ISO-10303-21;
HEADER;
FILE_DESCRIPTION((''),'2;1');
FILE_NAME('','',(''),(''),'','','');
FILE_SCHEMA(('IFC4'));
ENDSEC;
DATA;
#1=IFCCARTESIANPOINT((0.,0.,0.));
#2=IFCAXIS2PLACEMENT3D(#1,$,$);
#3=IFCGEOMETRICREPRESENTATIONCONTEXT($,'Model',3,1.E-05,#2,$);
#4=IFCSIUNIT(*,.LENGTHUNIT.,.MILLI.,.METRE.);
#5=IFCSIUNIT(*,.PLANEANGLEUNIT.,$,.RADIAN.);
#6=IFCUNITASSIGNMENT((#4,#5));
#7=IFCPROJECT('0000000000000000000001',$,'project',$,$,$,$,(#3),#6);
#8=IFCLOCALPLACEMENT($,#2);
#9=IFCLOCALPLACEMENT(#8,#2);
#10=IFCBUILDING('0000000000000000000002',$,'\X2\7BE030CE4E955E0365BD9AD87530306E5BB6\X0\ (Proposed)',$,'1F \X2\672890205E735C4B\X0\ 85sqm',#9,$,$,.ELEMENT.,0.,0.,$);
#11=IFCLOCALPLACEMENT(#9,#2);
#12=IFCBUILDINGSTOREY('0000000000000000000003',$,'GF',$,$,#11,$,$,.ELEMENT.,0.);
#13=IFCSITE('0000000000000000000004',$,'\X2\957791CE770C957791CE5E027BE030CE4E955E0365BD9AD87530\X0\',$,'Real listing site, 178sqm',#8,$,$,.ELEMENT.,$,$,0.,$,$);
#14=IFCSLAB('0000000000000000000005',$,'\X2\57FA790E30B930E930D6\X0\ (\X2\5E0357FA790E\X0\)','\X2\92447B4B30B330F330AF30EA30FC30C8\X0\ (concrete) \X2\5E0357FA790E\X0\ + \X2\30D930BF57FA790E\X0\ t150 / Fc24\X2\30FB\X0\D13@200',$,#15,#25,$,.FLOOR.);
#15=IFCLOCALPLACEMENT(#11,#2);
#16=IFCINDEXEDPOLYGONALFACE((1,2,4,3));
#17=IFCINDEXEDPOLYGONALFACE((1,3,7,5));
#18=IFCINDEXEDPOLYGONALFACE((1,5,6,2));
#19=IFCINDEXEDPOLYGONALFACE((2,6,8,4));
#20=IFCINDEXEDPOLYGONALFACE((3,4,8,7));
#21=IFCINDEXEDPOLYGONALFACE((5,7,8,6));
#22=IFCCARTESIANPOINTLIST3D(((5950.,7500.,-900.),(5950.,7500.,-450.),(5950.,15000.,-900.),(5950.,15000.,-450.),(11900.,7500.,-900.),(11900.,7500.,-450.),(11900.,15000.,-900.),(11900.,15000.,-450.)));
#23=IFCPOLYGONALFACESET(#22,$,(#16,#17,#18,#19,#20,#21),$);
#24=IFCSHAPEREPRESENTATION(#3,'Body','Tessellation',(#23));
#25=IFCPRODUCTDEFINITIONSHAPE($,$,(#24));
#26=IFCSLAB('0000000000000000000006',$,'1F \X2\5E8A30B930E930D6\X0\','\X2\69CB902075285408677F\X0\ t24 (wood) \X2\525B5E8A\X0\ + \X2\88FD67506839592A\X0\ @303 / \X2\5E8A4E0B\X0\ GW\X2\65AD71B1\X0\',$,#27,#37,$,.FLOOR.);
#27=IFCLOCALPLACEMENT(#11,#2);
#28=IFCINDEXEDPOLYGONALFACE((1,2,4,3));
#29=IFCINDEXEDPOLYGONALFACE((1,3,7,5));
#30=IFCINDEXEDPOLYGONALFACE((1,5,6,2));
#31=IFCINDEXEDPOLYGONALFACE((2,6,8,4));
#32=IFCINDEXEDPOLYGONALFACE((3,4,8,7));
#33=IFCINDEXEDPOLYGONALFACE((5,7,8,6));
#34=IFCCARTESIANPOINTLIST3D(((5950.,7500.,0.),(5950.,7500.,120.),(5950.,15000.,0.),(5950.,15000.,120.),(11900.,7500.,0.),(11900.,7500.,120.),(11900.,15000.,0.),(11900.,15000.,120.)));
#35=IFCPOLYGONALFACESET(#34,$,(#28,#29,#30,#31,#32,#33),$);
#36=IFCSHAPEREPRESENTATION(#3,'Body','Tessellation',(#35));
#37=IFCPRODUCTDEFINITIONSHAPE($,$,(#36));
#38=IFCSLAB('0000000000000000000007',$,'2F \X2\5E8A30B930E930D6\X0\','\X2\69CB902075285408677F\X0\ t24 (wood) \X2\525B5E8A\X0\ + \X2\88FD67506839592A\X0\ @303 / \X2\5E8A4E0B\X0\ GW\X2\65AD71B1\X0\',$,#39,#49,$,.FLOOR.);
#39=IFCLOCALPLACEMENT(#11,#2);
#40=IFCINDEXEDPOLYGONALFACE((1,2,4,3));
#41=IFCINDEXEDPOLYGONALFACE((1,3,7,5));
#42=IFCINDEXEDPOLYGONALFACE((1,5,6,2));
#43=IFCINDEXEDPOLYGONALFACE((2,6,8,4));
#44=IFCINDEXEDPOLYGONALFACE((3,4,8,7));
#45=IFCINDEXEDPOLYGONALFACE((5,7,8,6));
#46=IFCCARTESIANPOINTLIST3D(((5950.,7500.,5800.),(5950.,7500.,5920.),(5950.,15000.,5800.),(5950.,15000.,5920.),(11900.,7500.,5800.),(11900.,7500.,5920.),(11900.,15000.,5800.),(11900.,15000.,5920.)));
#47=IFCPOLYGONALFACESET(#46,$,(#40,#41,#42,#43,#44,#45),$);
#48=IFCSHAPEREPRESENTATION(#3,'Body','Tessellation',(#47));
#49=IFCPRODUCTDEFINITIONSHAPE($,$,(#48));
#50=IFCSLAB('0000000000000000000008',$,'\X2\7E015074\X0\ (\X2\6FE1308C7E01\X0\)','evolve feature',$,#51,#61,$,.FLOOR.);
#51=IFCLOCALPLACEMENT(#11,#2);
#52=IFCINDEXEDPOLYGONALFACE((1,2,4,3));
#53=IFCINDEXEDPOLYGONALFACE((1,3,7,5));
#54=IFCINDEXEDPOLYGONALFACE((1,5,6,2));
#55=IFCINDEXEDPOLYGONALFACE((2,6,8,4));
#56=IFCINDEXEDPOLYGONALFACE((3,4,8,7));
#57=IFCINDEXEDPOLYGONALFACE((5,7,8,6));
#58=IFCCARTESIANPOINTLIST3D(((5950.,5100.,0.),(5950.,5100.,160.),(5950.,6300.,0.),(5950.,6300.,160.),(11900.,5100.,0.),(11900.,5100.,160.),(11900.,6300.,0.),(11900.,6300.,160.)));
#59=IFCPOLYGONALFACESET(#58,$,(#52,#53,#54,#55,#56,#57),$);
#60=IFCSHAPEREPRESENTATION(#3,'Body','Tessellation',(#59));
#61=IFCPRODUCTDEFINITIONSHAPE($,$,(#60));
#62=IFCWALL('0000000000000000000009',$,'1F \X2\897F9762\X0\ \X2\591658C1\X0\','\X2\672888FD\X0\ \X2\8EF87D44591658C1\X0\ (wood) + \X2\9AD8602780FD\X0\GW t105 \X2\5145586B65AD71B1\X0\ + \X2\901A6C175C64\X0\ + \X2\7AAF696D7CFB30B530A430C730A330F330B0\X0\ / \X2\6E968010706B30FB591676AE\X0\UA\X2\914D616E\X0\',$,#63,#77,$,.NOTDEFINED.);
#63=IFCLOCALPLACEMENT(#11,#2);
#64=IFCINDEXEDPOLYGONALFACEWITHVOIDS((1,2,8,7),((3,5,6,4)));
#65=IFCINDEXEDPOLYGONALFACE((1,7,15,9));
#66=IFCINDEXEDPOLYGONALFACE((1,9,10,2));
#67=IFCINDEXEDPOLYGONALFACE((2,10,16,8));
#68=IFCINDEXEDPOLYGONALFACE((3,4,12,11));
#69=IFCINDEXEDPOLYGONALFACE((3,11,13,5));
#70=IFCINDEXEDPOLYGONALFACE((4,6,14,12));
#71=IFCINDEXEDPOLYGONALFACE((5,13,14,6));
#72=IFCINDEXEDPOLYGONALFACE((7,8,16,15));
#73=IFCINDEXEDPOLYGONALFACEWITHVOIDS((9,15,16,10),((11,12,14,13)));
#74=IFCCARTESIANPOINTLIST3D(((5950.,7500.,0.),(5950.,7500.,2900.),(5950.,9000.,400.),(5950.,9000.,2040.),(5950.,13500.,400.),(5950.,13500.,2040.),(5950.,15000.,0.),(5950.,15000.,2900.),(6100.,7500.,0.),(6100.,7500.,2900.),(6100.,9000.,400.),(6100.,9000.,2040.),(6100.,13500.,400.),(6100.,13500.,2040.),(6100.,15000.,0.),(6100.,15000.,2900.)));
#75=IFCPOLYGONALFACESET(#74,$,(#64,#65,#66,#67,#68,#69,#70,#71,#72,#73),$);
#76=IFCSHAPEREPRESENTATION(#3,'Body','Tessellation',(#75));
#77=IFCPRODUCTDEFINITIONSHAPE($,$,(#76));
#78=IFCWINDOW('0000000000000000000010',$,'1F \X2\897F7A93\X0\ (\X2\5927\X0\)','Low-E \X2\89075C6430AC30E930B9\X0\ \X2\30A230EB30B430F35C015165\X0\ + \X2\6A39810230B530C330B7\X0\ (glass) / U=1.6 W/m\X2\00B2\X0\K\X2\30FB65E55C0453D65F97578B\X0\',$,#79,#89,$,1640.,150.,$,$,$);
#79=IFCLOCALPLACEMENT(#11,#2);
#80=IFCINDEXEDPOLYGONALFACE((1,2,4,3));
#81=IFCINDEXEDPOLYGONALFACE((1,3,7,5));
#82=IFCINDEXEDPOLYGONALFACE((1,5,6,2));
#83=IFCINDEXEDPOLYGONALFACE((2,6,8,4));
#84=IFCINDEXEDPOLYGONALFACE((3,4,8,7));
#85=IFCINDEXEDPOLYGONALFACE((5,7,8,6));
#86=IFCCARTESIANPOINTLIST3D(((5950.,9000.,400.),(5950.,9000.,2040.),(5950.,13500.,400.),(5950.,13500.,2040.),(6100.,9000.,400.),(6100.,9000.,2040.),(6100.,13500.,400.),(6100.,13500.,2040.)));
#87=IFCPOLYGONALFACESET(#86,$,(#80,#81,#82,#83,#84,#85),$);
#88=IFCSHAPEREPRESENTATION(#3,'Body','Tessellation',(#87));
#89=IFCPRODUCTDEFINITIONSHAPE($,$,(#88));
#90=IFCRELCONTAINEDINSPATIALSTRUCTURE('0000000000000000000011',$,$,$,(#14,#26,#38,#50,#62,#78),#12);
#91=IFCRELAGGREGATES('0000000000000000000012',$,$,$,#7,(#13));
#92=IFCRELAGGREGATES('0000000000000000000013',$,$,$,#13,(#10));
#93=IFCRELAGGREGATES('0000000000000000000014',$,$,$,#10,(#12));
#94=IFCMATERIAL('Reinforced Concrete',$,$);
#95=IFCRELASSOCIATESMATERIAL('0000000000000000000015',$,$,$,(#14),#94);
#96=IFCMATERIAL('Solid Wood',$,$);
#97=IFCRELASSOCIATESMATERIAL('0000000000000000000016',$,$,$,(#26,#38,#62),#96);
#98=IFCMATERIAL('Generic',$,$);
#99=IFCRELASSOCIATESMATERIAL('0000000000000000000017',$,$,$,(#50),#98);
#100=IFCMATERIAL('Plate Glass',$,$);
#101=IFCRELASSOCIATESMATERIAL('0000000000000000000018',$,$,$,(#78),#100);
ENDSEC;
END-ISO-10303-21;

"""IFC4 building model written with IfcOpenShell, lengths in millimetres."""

from ifc_helpers import new_model, si_unit, frame, frame_2d, origin, place, context, project, spatial, rectangle, extrude, material, element, fill, save


model = new_model("IFC4")

# Units and contexts
model_context = context("Model", 3, precision=1e-05, world=origin())
ifc_project = project(units=[si_unit("LENGTHUNIT", "METRE", prefix="MILLI"), si_unit("PLANEANGLEUNIT", "RADIAN")], contexts=[model_context])

# Site, building, storey
site_placement = place(None, origin())
site = spatial("IfcSite", under=ifc_project, at=site_placement, Name="長野県長野市篠ノ井布施高田", ObjectType="Real listing site, 178sqm", CompositionType="ELEMENT", RefElevation=0.0)
building_placement = place(site_placement, origin())
building = spatial("IfcBuilding", under=site, at=building_placement, Name="篠ノ井布施高田の家 (Proposed)", ObjectType="1F 木造平屋 85sqm", CompositionType="ELEMENT", ElevationOfRefHeight=0.0, ElevationOfTerrain=0.0)
storey_placement = place(building_placement, origin())
storey = spatial("IfcBuildingStorey", under=building, at=storey_placement, Name="GF", CompositionType="ELEMENT", Elevation=0.0)

# Slabs
ifc_material_1 = material(Name="Reinforced Concrete")
slab_1_placement = place(storey_placement, frame((2975.0, 3750.0, -450.0)))
element("IfcSlab", 1, at=slab_1_placement, inside=storey, material=ifc_material_1, Name="基礎スラブ (布基礎)", Description="鉄筋コンクリート (concrete) 布基礎 + ベタ基礎 t150 / Fc24・D13@200", PredefinedType="FLOOR", context=model_context, shape_type="SweptSolid", body=[
    extrude(rectangle(XDim=5950.0, YDim=7500.0, at=frame_2d((2975.0, 3750.0))), frame((2975.0, 3750.0, -450.0)), (0.0, 0.0, 1.0), 450.0),
])
ifc_material_2 = material(Name="Solid Wood")
slab_2_placement = place(storey_placement, frame((2975.0, 3750.0, 0.0)))
element("IfcSlab", 2, at=slab_2_placement, inside=storey, material=ifc_material_2, Name="1F 床スラブ", Description="構造用合板 t24 (wood) 剛床 + 製材根太 @303 / 床下 GW断熱", PredefinedType="FLOOR", context=model_context, shape_type="SweptSolid", body=[
    extrude(rectangle(XDim=5950.0, YDim=7500.0, at=frame_2d((2975.0, 3750.0))), frame((2975.0, 3750.0, 0.0)), (0.0, 0.0, 1.0), 120.0),
])
slab_3_placement = place(storey_placement, frame((2975.0, 3750.0, 2900.0)))
element("IfcSlab", 3, at=slab_3_placement, inside=storey, material=ifc_material_2, Name="2F 床スラブ", Description="構造用合板 t24 (wood) 剛床 + 製材根太 @303 / 床下 GW断熱", PredefinedType="FLOOR", context=model_context, shape_type="SweptSolid", body=[
    extrude(rectangle(XDim=5950.0, YDim=7500.0, at=frame_2d((2975.0, 3750.0))), frame((2975.0, 3750.0, 2900.0)), (0.0, 0.0, 1.0), 120.0),
])
ifc_material_3 = material(Name="Generic")
slab_4_placement = place(storey_placement, frame((2975.0, 2550.0, 0.0)))
element("IfcSlab", 4, at=slab_4_placement, inside=storey, material=ifc_material_3, Name="縁側 (濡れ縁)", Description="evolve feature", PredefinedType="FLOOR", context=model_context, shape_type="SweptSolid", body=[
    extrude(rectangle(XDim=5950.0, YDim=1200.0, at=frame_2d((2975.0, 600.0))), frame((2975.0, 2550.0, 0.0)), (0.0, 0.0, 1.0), 160.0),
])

# Shared definitions
ifc_material_4 = material(Name="Plate Glass")

# Wall, opening, window
wall_1_placement = place(storey_placement, frame((2975.0, 3750.0, 0.0)))
wall_1 = element("IfcWall", 5, at=wall_1_placement, inside=storey, material=ifc_material_2, Name="1F 西面 外壁", Description="木製 軸組外壁 (wood) + 高性能GW t105 充填断熱 + 通気層 + 窯業系サイディング / 準耐火・外皮UA配慮", PredefinedType="NOTDEFINED", context=model_context, shape_type="SweptSolid", body=[
    extrude(rectangle(XDim=150.0, YDim=7500.0, at=frame_2d((75.0, 3750.0))), frame((2975.0, 3750.0, 0.0)), (0.0, 0.0, 1.0), 2900.0),
])
opening_1_placement = place(storey_placement, frame((2975.0, 4500.0, 200.0)))
opening_1 = element("IfcOpeningElement", 6, at=opening_1_placement, cuts=wall_1, PredefinedType="NOTDEFINED", context=model_context, shape_type="SweptSolid", body=[
    extrude(rectangle(XDim=150.0, YDim=4500.0, at=frame_2d((75.0, 2250.0))), frame((2975.0, 4500.0, 200.0)), (0.0, 0.0, 1.0), 1640.0),
])
window_1_placement = place(storey_placement, frame((2975.0, 4500.0, 200.0)))
window_1 = element("IfcWindow", 7, at=window_1_placement, inside=storey, material=ifc_material_4, Name="1F 西窓 (大)", Description="Low-E 複層ガラス アルゴン封入 + 樹脂サッシ (glass) / U=1.6 W/m²K・日射取得型", OverallHeight=1640.0, OverallWidth=150.0, context=model_context, shape_type="SweptSolid", body=[
    extrude(rectangle(XDim=150.0, YDim=4500.0, at=frame_2d((75.0, 2250.0))), frame((2975.0, 4500.0, 200.0)), (0.0, 0.0, 1.0), 1640.0),
])
fill(opening_1, window_1)

save(model, "model.ifc")
